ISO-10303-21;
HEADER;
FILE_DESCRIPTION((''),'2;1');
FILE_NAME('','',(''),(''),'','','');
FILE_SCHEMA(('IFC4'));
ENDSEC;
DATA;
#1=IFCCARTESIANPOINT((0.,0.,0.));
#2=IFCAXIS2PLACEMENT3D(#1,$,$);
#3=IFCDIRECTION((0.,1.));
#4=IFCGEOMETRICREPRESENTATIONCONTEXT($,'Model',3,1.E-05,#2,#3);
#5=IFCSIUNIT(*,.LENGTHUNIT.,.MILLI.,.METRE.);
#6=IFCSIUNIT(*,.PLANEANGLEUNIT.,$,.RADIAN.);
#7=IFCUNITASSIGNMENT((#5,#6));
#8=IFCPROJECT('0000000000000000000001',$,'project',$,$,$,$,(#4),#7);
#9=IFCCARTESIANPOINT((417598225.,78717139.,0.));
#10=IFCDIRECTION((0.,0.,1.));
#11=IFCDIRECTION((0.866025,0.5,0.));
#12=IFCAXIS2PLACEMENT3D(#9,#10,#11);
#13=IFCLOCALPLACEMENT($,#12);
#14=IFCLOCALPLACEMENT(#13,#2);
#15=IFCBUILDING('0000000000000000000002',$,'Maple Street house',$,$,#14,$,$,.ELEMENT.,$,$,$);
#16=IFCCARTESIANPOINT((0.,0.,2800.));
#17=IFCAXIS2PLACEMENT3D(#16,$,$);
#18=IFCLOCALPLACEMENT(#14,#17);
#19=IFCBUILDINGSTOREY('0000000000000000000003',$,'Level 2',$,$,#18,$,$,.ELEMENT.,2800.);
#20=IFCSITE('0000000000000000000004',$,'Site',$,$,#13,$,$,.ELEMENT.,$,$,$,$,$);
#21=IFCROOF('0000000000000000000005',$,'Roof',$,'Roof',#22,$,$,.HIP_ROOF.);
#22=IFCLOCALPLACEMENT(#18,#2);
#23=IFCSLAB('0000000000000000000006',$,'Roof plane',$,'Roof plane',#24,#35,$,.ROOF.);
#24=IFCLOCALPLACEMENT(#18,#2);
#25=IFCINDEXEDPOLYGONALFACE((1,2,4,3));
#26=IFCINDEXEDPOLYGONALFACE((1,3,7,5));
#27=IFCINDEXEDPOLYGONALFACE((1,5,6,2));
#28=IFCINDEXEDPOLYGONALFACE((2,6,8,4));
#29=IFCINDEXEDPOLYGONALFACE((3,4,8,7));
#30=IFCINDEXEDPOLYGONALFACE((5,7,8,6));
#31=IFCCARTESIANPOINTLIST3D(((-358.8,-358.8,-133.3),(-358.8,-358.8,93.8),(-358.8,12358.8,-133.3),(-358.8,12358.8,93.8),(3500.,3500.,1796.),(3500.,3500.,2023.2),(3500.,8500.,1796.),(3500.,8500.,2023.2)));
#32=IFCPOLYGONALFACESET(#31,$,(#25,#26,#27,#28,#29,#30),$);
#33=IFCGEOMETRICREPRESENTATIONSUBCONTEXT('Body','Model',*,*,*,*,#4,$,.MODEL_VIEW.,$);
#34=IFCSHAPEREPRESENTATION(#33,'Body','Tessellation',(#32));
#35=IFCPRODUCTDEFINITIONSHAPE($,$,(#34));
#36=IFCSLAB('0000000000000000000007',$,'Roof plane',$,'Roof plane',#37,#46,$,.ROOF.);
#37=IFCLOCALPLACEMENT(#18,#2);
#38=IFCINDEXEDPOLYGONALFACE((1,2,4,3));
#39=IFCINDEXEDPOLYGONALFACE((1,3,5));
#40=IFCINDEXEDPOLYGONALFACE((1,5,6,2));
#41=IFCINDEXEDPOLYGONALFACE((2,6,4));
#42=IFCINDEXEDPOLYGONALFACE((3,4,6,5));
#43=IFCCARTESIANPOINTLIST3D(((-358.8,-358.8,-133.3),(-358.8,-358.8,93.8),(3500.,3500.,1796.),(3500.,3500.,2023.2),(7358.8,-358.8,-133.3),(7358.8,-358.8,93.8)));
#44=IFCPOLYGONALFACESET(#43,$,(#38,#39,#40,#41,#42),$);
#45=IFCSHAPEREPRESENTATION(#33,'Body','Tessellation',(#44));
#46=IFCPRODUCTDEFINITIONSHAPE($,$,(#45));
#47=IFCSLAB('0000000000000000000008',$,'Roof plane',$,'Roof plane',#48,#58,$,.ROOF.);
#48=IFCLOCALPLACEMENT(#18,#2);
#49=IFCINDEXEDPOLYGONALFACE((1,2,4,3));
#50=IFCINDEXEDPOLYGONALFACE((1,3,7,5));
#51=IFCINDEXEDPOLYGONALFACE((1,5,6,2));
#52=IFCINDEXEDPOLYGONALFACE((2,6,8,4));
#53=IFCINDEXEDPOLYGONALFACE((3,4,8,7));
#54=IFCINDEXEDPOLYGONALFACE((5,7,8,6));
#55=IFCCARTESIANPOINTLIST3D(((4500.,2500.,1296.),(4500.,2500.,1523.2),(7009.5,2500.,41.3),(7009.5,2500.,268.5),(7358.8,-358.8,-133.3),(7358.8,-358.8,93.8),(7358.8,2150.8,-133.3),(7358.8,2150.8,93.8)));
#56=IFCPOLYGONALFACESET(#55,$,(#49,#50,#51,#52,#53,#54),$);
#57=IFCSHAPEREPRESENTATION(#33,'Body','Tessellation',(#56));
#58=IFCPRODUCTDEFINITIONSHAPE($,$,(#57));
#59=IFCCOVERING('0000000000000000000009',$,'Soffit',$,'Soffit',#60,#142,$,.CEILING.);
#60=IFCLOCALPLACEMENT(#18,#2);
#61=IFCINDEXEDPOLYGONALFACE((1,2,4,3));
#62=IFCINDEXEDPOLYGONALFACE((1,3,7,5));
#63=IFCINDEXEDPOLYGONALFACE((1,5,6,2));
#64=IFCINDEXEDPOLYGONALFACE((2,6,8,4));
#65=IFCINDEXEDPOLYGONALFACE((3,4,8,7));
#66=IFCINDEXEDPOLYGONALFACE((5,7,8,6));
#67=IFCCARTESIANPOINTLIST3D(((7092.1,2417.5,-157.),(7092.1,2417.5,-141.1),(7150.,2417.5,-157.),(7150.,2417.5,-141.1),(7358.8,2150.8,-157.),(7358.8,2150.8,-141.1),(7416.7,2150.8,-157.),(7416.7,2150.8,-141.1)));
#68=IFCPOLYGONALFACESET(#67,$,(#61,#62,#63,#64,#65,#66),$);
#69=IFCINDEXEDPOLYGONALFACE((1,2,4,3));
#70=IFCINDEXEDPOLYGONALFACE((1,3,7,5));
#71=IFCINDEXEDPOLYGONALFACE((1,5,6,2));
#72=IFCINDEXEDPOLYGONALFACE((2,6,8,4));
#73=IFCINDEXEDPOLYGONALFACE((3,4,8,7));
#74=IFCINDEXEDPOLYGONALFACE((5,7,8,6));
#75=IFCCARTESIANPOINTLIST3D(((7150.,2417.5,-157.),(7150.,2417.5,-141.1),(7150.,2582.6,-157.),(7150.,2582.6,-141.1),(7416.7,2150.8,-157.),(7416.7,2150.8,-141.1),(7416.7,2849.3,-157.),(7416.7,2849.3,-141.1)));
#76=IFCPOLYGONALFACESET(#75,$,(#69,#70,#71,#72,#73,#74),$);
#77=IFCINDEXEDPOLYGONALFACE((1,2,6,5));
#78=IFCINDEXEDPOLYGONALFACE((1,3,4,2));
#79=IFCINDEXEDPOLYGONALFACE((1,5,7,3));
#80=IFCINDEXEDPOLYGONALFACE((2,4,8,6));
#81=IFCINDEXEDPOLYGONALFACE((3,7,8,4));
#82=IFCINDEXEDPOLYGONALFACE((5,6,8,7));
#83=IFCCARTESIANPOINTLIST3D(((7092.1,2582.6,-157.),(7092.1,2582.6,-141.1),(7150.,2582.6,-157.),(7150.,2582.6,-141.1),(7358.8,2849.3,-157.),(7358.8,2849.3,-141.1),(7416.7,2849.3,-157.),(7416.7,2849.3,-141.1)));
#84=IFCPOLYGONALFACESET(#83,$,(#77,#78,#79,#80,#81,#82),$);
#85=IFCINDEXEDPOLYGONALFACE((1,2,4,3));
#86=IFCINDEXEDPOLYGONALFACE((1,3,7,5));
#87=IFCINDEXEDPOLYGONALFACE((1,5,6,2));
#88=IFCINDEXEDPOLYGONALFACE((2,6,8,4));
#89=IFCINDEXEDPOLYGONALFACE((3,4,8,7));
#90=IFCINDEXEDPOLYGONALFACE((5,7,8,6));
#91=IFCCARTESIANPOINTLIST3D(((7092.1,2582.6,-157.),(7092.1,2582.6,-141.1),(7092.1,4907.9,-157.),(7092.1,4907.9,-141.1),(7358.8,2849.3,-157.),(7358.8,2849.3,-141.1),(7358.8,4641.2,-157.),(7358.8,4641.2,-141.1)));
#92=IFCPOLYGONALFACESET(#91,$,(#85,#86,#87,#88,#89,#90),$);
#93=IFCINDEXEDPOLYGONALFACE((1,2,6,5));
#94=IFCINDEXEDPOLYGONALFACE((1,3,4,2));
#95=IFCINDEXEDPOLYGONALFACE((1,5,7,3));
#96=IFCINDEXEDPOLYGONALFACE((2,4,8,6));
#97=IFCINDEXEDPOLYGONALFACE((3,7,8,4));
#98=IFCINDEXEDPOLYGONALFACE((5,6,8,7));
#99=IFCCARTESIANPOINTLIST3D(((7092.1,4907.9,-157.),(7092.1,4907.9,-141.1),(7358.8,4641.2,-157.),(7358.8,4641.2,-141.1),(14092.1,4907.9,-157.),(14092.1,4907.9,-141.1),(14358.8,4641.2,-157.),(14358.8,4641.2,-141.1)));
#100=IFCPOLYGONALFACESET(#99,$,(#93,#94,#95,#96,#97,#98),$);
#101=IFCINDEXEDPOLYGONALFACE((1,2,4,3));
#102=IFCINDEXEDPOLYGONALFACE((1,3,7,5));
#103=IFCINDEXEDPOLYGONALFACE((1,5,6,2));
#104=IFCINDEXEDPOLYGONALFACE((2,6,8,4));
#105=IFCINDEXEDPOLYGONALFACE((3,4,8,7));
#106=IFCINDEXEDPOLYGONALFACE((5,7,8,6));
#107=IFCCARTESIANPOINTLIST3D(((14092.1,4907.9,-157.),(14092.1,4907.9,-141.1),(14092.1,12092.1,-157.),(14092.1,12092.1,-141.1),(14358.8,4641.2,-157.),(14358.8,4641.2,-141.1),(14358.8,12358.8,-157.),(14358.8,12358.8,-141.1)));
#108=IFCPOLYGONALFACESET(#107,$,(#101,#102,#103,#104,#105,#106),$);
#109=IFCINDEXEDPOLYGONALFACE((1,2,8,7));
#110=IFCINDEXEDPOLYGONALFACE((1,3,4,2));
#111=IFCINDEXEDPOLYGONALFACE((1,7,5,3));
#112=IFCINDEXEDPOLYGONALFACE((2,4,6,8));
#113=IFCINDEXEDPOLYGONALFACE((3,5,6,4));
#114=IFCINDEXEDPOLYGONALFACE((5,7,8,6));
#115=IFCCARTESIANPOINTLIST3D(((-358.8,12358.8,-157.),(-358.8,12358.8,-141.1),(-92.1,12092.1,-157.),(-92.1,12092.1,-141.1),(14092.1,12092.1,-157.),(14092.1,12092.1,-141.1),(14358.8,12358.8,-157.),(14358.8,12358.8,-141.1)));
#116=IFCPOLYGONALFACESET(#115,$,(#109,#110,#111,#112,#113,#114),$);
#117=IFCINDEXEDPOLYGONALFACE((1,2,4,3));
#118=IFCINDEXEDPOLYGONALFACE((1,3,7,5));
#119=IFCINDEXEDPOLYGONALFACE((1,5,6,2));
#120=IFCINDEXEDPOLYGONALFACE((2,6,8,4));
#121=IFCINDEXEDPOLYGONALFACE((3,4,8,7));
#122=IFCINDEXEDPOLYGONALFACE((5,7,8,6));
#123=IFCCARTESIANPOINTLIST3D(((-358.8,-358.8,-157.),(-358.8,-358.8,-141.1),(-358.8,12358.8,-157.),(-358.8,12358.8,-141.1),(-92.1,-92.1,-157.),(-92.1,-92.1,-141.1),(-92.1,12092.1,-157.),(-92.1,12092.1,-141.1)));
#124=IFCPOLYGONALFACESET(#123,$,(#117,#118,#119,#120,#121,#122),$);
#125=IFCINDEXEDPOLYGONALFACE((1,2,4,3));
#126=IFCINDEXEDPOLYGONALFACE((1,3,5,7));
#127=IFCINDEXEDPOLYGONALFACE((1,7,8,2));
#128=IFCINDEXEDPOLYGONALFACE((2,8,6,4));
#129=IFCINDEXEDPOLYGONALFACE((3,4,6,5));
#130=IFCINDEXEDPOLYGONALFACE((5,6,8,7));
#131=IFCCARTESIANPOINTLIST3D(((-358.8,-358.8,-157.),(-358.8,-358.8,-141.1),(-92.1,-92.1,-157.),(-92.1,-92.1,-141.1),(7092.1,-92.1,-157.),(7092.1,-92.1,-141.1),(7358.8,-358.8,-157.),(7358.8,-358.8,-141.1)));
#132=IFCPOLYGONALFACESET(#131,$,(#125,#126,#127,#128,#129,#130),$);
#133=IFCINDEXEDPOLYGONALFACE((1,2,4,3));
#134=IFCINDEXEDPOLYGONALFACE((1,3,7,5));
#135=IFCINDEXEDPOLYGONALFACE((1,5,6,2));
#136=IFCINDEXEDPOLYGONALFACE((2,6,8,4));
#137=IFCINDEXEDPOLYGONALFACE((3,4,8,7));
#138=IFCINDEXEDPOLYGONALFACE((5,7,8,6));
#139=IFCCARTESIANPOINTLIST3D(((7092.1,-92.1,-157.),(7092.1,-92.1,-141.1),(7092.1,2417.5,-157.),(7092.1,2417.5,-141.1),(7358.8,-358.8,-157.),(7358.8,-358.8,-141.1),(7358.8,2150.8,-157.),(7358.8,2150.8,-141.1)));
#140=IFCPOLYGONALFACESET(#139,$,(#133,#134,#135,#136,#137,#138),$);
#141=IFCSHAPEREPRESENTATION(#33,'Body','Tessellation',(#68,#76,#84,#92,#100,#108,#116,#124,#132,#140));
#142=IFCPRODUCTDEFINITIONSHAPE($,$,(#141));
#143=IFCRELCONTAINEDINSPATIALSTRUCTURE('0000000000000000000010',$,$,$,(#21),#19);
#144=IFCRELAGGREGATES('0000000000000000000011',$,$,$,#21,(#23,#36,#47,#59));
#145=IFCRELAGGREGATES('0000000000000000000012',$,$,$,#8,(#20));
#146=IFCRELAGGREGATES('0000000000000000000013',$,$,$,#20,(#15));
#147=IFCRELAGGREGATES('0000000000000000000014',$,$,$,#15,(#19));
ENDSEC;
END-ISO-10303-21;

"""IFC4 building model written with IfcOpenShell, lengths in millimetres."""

from ifc_helpers import new_model, si_unit, direction, frame, origin, origin_with_axes, place, context, subcontext, project, spatial, polyline, outline, extrude, element, aggregate, save


model = new_model("IFC4")

# Units and contexts
model_context = context("Model", 3, precision=1e-05, world=origin(), true_north=direction((0.0, 1.0)))
body_context = subcontext(model_context, "Body", "Model", "MODEL_VIEW")
ifc_project = project(units=[si_unit("LENGTHUNIT", "METRE", prefix="MILLI"), si_unit("PLANEANGLEUNIT", "RADIAN")], contexts=[model_context])

# Site, building, storey
site_placement = place(None, frame((417598225.0, 78717139.0, 0.0), z_axis=(0.0, 0.0, 1.0), x_axis=(0.866025, 0.5, 0.0)))
site = spatial("IfcSite", under=ifc_project, at=site_placement, Name="Site", CompositionType="ELEMENT")
building_placement = place(site_placement, origin())
building = spatial("IfcBuilding", under=site, at=building_placement, Name="Maple Street house", CompositionType="ELEMENT")
storey_placement = place(building_placement, frame((0.0, 0.0, 2800.0)))
storey = spatial("IfcBuildingStorey", under=building, at=storey_placement, Name="Level 2", CompositionType="ELEMENT", Elevation=2800.0)

# Roof
roof_1_placement = place(storey_placement, origin_with_axes())
roof_1 = element("IfcRoof", 1, at=roof_1_placement, inside=storey, Name="Roof", ObjectType="Roof", PredefinedType="HIP_ROOF")

# Slabs
slab_1_placement = place(storey_placement, origin_with_axes())
slab_1 = element("IfcSlab", 2, at=slab_1_placement, Name="Roof plane", ObjectType="Roof plane", PredefinedType="ROOF", context=body_context, shape_type="SweptSolid", body=[
    extrude(outline(polyline([(-12358.8, 0.0), (358.8, 0.0), (-3500.0, 4314.2), (-8500.0, 4314.2), (-12358.8, 0.0)])), frame((-358.8, 0.0, -133.3), z_axis=(-0.447214, 0.0, 0.894427), x_axis=(0.0, -1.0, 0.0)), (0.0, 0.447214, 0.894427), 227.2),
])
slab_2_placement = place(storey_placement, origin_with_axes())
slab_2 = element("IfcSlab", 3, at=slab_2_placement, Name="Roof plane", ObjectType="Roof plane", PredefinedType="ROOF", context=body_context, shape_type="SweptSolid", body=[
    extrude(outline(polyline([(-358.8, 0.0), (7358.8, 0.0), (3500.0, 4314.2), (-358.8, 0.0)])), frame((0.0, -358.8, -133.3), z_axis=(0.0, -0.447214, 0.894427), x_axis=(1.0, 0.0, 0.0)), (0.0, 0.447214, 0.894427), 227.2),
])
slab_3_placement = place(storey_placement, origin_with_axes())
slab_3 = element("IfcSlab", 4, at=slab_3_placement, Name="Roof plane", ObjectType="Roof plane", PredefinedType="ROOF", context=body_context, shape_type="SweptSolid", body=[
    extrude(outline(polyline([(-358.8, 0.0), (2150.8, 0.0), (2500.0, 390.5), (2500.0, 3196.2), (-358.8, 0.0)])), frame((7358.8, 0.0, -133.3), z_axis=(0.447214, 0.0, 0.894427), x_axis=(0.0, 1.0, 0.0)), (0.0, 0.447214, 0.894427), 227.2),
])

# Covering
covering_placement = place(storey_placement, origin_with_axes())
covering = element("IfcCovering", 5, at=covering_placement, Name="Soffit", ObjectType="Soffit", PredefinedType="CEILING", context=body_context, shape_type="SweptSolid", body=[
    extrude(outline(polyline([(7092.1, 2417.5), (7150.0, 2417.5), (7416.7, 2150.8), (7358.8, 2150.8), (7092.1, 2417.5)])), frame((0.0, 0.0, -157.0), z_axis=(0.0, 0.0, 1.0), x_axis=(1.0, 0.0, 0.0)), (0.0, 0.0, 1.0), 15.9),
    extrude(outline(polyline([(7150.0, 2417.5), (7150.0, 2582.6), (7416.7, 2849.3), (7416.7, 2150.8), (7150.0, 2417.5)])), frame((0.0, 0.0, -157.0), z_axis=(0.0, 0.0, 1.0), x_axis=(1.0, 0.0, 0.0)), (0.0, 0.0, 1.0), 15.9),
    extrude(outline(polyline([(7150.0, 2582.6), (7092.1, 2582.6), (7358.8, 2849.3), (7416.7, 2849.3), (7150.0, 2582.6)])), frame((0.0, 0.0, -157.0), z_axis=(0.0, 0.0, 1.0), x_axis=(1.0, 0.0, 0.0)), (0.0, 0.0, 1.0), 15.9),
    extrude(outline(polyline([(7092.1, 2582.6), (7092.1, 4907.9), (7358.8, 4641.2), (7358.8, 2849.3), (7092.1, 2582.6)])), frame((0.0, 0.0, -157.0), z_axis=(0.0, 0.0, 1.0), x_axis=(1.0, 0.0, 0.0)), (0.0, 0.0, 1.0), 15.9),
    extrude(outline(polyline([(7092.1, 4907.9), (14092.1, 4907.9), (14358.8, 4641.2), (7358.8, 4641.2), (7092.1, 4907.9)])), frame((0.0, 0.0, -157.0), z_axis=(0.0, 0.0, 1.0), x_axis=(1.0, 0.0, 0.0)), (0.0, 0.0, 1.0), 15.9),
    extrude(outline(polyline([(14092.1, 4907.9), (14092.1, 12092.1), (14358.8, 12358.8), (14358.8, 4641.2), (14092.1, 4907.9)])), frame((0.0, 0.0, -157.0), z_axis=(0.0, 0.0, 1.0), x_axis=(1.0, 0.0, 0.0)), (0.0, 0.0, 1.0), 15.9),
    extrude(outline(polyline([(14092.1, 12092.1), (-92.1, 12092.1), (-358.8, 12358.8), (14358.8, 12358.8), (14092.1, 12092.1)])), frame((0.0, 0.0, -157.0), z_axis=(0.0, 0.0, 1.0), x_axis=(1.0, 0.0, 0.0)), (0.0, 0.0, 1.0), 15.9),
    extrude(outline(polyline([(-92.1, 12092.1), (-92.1, -92.1), (-358.8, -358.8), (-358.8, 12358.8), (-92.1, 12092.1)])), frame((0.0, 0.0, -157.0), z_axis=(0.0, 0.0, 1.0), x_axis=(1.0, 0.0, 0.0)), (0.0, 0.0, 1.0), 15.9),
    extrude(outline(polyline([(-92.1, -92.1), (7092.1, -92.1), (7358.8, -358.8), (-358.8, -358.8), (-92.1, -92.1)])), frame((0.0, 0.0, -157.0), z_axis=(0.0, 0.0, 1.0), x_axis=(1.0, 0.0, 0.0)), (0.0, 0.0, 1.0), 15.9),
    extrude(outline(polyline([(7092.1, -92.1), (7092.1, 2417.5), (7358.8, 2150.8), (7358.8, -358.8), (7092.1, -92.1)])), frame((0.0, 0.0, -157.0), z_axis=(0.0, 0.0, 1.0), x_axis=(1.0, 0.0, 0.0)), (0.0, 0.0, 1.0), 15.9),
])
aggregate(roof_1, [slab_1, slab_2, slab_3, covering])

save(model, "model.ifc")
